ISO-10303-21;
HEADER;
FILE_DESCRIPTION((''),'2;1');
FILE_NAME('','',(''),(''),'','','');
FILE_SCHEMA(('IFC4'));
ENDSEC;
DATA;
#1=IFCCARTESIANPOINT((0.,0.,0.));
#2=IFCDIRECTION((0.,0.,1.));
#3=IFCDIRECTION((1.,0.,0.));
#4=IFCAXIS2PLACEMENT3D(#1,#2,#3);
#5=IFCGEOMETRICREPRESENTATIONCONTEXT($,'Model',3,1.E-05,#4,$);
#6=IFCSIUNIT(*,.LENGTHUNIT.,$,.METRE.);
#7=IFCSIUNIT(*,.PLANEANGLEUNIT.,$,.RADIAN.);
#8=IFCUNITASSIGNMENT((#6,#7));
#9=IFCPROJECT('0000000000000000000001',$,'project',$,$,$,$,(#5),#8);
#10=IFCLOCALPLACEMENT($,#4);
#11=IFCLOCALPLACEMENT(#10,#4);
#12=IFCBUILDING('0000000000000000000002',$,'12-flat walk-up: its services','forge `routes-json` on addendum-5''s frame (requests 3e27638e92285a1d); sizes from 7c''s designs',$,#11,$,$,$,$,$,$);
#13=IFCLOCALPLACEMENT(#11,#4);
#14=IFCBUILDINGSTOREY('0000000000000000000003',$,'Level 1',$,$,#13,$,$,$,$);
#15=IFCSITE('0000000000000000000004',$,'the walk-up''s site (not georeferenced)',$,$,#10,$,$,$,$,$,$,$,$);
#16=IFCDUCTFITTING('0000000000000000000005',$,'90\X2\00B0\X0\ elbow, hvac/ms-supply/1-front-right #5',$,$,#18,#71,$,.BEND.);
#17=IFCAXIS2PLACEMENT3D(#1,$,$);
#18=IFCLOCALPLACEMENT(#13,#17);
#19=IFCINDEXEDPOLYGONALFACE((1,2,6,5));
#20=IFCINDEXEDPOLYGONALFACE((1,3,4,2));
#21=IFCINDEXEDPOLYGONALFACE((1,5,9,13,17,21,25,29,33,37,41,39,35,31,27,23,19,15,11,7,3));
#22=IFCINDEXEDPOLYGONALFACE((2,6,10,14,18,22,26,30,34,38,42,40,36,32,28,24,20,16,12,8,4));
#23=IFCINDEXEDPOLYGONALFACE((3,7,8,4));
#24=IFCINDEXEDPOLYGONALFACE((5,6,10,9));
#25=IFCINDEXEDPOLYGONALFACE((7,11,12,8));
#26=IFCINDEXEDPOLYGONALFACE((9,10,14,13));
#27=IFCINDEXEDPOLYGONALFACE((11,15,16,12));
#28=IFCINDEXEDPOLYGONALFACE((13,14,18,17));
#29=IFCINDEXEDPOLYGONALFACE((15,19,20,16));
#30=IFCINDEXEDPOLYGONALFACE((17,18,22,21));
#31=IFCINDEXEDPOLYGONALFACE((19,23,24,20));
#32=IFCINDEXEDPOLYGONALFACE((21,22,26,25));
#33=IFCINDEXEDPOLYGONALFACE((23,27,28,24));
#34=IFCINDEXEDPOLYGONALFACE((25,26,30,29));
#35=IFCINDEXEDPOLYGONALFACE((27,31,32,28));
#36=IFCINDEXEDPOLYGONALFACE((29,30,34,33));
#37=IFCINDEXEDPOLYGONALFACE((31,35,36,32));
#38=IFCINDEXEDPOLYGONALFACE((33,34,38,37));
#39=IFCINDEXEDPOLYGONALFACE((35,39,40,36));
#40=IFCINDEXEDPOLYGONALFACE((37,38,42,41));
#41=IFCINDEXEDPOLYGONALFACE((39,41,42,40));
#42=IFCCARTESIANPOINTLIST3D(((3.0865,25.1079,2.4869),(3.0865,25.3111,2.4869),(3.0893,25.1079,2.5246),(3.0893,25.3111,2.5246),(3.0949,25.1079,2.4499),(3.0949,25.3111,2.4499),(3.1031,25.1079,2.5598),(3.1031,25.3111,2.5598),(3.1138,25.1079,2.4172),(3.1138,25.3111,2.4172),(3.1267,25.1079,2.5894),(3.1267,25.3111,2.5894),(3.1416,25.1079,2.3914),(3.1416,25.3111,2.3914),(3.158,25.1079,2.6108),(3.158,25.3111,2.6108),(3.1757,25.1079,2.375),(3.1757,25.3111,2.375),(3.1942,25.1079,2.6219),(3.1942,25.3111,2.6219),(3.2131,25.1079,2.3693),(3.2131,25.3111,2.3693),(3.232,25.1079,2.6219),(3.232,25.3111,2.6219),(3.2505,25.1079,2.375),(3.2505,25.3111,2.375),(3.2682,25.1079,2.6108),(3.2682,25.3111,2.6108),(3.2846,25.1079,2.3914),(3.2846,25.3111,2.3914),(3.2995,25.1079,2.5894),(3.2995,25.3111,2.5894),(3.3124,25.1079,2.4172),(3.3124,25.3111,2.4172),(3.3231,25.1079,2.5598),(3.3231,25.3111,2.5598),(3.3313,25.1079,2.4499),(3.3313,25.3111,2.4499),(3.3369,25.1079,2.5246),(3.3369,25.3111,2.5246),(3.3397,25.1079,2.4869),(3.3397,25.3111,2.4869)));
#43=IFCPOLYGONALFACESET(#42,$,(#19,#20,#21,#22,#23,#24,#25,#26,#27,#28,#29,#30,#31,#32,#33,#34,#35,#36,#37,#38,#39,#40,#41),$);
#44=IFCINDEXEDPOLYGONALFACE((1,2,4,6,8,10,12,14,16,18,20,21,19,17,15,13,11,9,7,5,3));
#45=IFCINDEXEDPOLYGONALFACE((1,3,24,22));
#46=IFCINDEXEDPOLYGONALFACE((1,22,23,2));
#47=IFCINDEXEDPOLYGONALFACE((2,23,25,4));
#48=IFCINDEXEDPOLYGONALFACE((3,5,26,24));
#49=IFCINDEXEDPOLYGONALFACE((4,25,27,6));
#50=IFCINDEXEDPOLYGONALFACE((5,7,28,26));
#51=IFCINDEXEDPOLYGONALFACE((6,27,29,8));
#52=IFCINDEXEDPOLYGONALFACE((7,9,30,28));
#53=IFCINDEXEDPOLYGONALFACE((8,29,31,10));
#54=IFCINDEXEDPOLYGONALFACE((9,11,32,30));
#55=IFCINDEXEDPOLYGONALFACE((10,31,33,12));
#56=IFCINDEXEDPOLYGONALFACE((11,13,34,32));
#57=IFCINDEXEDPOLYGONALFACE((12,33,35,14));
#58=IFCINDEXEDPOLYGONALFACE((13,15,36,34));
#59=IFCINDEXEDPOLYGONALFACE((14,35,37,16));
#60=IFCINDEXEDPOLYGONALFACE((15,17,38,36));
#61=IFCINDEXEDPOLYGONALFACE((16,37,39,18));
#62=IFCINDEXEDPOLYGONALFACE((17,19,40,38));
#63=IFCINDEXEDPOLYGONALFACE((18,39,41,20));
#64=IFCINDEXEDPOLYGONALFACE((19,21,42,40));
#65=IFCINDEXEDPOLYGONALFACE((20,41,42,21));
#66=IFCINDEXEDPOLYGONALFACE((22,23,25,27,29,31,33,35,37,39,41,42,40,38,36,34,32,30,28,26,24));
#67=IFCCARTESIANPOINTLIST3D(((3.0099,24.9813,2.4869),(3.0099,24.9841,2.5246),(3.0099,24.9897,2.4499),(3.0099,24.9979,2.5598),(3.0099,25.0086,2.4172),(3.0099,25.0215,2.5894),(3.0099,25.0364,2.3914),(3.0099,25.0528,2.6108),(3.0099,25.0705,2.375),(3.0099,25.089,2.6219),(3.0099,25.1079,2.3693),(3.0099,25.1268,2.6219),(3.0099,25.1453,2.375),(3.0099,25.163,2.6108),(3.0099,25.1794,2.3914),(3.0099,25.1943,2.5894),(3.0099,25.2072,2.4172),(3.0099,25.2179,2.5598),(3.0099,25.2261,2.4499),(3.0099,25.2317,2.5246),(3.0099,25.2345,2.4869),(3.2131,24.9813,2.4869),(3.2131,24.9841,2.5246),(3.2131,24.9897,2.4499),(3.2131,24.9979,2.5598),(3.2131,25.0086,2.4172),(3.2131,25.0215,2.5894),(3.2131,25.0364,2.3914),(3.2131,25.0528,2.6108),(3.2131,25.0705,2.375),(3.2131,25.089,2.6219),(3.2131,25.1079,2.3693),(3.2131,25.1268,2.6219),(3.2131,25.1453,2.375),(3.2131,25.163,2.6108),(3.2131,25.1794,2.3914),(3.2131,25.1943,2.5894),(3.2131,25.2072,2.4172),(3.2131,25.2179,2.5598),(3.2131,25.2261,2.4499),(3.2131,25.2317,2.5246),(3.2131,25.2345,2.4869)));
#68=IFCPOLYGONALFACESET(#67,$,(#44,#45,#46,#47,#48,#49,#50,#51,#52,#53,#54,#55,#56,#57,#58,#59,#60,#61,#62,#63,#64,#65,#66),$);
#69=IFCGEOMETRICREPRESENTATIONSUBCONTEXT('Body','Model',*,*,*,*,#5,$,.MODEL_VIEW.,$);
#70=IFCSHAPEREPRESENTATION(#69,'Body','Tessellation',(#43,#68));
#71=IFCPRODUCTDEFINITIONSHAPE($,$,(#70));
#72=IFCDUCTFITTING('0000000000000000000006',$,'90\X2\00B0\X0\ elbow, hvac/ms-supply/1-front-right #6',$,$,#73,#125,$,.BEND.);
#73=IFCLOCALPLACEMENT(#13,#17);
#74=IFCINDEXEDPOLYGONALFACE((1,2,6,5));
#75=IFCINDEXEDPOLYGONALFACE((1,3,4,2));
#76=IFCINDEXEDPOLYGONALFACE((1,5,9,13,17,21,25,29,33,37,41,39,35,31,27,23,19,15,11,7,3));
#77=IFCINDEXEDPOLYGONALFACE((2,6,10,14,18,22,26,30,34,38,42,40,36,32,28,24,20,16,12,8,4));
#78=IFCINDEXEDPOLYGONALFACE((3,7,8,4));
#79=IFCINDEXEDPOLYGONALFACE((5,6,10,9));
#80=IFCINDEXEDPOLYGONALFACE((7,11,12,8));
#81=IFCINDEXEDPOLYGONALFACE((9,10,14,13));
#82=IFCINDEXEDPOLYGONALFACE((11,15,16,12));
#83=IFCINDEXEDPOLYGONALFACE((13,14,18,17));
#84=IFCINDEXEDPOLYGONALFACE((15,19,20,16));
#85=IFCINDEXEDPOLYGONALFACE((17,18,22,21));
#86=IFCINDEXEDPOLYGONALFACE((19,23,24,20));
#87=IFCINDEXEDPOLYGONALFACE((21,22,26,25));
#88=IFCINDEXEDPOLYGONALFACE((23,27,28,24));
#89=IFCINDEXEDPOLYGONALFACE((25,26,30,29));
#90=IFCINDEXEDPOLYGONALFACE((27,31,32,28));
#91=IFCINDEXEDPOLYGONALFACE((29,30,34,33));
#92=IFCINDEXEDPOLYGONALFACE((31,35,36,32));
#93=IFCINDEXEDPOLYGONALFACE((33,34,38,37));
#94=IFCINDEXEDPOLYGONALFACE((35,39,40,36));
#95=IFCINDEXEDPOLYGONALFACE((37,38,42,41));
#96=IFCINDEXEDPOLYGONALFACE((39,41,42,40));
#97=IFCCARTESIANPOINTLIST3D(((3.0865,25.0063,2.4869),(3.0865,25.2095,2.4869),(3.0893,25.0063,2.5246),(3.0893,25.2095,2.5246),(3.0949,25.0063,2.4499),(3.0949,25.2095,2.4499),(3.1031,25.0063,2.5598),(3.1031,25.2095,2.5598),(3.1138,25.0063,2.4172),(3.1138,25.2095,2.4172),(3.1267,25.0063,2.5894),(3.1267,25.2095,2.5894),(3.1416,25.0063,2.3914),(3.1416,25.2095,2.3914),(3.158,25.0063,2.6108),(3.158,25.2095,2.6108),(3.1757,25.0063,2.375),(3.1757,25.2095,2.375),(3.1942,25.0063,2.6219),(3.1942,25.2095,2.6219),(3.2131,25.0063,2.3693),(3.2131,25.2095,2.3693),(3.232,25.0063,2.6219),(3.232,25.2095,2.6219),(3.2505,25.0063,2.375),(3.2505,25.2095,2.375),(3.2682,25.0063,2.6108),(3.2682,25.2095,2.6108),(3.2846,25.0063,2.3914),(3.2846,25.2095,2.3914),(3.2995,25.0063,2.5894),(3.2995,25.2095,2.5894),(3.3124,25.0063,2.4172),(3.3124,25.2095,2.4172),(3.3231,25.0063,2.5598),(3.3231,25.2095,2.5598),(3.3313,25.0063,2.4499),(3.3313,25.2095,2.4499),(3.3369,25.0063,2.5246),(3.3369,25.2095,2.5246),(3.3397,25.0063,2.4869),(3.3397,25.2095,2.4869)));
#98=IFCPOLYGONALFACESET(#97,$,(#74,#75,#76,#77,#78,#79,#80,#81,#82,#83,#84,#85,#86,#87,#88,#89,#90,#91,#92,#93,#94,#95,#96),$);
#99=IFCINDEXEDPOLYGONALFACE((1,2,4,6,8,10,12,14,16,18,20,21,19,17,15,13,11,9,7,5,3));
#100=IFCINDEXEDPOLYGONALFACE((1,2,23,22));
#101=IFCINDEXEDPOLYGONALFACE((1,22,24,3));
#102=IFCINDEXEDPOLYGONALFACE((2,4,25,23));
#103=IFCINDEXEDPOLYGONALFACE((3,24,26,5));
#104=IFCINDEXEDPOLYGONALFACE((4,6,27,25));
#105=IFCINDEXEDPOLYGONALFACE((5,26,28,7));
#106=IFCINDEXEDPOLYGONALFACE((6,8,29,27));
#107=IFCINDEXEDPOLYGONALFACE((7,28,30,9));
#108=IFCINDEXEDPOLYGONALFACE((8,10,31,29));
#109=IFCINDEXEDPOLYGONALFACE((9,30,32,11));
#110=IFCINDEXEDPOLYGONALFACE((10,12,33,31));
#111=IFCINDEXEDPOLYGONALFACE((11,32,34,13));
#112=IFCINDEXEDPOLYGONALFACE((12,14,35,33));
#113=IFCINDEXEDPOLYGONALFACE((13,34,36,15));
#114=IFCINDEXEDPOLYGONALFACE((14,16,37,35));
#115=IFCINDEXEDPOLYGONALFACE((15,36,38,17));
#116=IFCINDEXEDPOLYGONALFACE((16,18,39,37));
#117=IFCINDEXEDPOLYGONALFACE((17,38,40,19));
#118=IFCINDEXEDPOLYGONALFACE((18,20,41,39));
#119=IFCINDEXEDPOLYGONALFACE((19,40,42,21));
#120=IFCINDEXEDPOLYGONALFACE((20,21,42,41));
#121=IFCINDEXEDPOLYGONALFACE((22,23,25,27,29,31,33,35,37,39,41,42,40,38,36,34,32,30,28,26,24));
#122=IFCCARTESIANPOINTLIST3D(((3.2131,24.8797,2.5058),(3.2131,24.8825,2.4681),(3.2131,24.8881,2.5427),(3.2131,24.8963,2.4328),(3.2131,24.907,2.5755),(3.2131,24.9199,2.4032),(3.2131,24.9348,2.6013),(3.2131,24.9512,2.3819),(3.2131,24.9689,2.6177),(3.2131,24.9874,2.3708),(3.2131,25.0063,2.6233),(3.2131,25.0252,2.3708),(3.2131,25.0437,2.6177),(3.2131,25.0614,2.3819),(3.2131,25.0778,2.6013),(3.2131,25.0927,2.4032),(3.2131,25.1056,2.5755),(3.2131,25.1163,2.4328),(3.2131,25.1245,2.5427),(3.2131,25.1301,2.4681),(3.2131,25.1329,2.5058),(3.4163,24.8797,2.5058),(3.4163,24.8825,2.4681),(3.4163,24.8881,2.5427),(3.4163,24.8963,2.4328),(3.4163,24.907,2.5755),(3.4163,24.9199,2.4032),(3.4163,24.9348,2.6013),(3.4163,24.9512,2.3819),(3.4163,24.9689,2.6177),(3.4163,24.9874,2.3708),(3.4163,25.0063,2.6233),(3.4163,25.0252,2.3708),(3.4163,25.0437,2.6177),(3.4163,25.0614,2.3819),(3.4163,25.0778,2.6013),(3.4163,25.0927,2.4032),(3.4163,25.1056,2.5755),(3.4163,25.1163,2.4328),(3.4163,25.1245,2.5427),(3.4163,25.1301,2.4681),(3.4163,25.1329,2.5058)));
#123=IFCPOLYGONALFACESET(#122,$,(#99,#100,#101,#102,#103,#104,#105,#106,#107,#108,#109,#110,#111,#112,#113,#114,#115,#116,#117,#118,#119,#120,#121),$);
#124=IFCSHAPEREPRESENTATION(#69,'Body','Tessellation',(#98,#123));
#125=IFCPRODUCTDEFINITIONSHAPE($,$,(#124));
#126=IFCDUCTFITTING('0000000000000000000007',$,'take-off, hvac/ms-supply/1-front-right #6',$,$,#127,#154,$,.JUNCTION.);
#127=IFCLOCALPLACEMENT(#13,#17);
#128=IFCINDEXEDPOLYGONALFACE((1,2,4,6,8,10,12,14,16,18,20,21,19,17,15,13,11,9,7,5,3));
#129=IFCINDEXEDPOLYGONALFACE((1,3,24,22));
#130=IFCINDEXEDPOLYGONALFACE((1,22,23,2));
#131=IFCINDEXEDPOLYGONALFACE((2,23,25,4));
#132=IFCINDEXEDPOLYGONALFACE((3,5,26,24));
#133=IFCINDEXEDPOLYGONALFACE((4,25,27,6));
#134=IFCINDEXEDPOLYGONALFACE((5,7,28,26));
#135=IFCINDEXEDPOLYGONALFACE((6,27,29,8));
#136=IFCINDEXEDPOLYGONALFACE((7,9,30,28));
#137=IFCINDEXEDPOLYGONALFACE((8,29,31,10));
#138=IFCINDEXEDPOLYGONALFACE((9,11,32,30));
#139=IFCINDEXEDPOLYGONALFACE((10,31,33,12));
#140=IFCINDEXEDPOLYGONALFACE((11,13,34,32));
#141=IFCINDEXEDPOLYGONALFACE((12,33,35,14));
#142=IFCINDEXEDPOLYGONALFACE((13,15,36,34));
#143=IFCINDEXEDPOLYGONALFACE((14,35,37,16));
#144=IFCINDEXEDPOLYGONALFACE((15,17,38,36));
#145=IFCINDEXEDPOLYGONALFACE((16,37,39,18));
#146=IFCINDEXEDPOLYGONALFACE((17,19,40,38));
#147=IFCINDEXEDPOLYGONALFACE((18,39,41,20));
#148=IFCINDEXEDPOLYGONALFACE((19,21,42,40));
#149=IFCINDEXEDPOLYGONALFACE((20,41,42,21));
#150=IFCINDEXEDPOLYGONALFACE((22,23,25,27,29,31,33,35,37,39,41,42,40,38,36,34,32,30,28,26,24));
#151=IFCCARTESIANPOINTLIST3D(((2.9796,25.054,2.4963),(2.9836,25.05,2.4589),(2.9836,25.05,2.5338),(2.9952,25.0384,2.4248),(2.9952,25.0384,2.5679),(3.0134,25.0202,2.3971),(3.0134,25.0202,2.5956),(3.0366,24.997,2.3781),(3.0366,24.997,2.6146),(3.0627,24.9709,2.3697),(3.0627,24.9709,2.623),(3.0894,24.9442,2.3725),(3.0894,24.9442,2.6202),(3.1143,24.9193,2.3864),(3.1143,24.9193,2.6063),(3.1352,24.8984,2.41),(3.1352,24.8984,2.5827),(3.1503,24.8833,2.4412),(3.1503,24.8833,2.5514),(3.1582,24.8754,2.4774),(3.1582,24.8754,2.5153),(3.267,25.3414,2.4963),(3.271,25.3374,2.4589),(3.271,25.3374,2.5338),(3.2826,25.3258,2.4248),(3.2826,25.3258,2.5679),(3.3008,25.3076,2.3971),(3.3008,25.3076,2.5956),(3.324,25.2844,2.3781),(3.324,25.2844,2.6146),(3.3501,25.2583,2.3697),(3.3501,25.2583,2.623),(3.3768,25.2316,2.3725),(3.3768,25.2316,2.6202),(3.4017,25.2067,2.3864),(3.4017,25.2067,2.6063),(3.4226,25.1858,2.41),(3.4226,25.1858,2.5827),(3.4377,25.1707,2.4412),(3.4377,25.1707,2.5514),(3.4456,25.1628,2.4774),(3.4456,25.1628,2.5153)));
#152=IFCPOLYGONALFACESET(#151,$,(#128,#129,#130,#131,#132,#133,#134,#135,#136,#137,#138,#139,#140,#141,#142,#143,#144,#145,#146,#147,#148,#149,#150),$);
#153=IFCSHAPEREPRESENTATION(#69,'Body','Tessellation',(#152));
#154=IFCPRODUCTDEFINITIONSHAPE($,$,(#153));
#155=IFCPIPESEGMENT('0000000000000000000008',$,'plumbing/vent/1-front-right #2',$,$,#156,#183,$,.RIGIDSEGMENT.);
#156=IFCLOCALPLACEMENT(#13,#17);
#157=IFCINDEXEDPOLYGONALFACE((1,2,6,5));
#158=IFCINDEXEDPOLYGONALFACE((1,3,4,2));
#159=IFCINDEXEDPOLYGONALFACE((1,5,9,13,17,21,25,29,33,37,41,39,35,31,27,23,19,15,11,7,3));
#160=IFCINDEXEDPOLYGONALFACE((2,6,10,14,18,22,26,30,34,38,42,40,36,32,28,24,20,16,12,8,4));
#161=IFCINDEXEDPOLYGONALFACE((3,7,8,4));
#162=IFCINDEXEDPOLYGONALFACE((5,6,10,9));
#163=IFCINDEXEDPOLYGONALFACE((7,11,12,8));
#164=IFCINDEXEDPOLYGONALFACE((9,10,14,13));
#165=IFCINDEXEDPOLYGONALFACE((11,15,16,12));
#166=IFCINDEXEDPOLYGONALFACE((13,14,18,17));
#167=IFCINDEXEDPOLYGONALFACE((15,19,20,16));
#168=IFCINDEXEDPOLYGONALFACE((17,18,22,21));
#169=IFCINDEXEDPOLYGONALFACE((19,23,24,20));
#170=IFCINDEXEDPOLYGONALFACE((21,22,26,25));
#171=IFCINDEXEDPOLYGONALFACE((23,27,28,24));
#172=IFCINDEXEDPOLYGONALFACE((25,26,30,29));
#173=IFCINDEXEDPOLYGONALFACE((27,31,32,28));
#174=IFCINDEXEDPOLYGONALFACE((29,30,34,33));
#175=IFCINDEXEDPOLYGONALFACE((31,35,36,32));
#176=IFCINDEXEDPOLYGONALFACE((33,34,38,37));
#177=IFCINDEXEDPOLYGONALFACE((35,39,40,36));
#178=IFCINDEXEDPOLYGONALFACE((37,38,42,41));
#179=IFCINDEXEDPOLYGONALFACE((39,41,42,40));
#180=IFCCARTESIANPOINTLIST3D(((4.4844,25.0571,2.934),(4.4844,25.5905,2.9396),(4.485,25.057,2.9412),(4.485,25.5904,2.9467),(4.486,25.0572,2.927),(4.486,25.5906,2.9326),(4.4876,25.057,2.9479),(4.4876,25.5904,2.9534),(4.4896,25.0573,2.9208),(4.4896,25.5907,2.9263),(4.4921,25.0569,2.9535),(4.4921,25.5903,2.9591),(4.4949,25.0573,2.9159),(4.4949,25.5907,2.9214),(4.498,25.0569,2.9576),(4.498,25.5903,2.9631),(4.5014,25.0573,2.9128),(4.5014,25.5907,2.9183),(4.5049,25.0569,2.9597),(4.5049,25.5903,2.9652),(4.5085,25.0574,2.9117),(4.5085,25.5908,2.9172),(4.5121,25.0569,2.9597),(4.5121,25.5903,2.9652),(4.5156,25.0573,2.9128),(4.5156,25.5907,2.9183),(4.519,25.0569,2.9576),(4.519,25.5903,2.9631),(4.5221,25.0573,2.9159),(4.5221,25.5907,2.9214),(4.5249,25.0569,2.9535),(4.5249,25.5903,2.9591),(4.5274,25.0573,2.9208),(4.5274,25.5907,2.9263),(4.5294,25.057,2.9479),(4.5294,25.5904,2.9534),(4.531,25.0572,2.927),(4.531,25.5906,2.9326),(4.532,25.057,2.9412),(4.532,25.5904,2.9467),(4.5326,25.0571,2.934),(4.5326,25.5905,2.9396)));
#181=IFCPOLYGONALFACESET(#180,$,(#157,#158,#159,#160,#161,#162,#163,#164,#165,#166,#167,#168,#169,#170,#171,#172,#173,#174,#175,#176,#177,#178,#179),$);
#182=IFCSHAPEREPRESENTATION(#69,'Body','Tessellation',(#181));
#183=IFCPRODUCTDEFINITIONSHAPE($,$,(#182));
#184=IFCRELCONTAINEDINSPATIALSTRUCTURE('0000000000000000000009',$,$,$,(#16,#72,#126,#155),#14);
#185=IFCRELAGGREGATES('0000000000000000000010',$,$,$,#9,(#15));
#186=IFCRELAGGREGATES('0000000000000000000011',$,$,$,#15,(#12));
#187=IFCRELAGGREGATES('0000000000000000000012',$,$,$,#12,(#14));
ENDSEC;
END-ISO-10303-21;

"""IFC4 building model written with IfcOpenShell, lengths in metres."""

from ifc_helpers import new_model, entity, si_unit, frame, origin_with_axes, place, context, subcontext, project, spatial, element, save


model = new_model("IFC4")

# Units and contexts
model_context = context("Model", 3, precision=1e-05, world=origin_with_axes())
body_context = subcontext(model_context, "Body", "Model", "MODEL_VIEW")
ifc_project = project(units=[si_unit("LENGTHUNIT", "METRE"), si_unit("PLANEANGLEUNIT", "RADIAN")], contexts=[model_context])

# Site, building, storey
site_placement = place(None, origin_with_axes())
site = spatial("IfcSite", under=ifc_project, at=site_placement, Name="the walk-up's site (not georeferenced)")
building_placement = place(site_placement, origin_with_axes())
building = spatial("IfcBuilding", under=site, at=building_placement, Name="12-flat walk-up: its services", Description="forge `routes-json` on addendum-5's frame (requests 3e27638e92285a1d); sizes from 7c's designs")
storey_placement = place(building_placement, origin_with_axes())
storey = spatial("IfcBuildingStorey", under=building, at=storey_placement, Name="Level 1")

# Duct fittings
duct_fitting_1_placement = place(storey_placement, frame((3.2131, 25.3111, 2.4963), z_axis=(0.0, 0.0, 1.0), x_axis=(1.0, 0.0, 0.0)))
element("IfcDuctFitting", 1, at=duct_fitting_1_placement, inside=storey, Name="90° elbow, hvac/ms-supply/1-front-right #5", PredefinedType="BEND", context=body_context, shape_type="AdvancedSweptSolid", body=[
    entity("IfcSweptDiskSolid", entity("IfcPolyline", [entity("IfcCartesianPoint", [0.0, 0.0, 0.0]), entity("IfcCartesianPoint", [0.0, -0.2032, 0.0])]), 0.127),
    entity("IfcSweptDiskSolid", entity("IfcPolyline", [entity("IfcCartesianPoint", [0.0, -0.2032, 0.0]), entity("IfcCartesianPoint", [-0.2032, -0.2032, 0.0])]), 0.127),
])
duct_fitting_2_placement = place(storey_placement, frame((3.2131, 25.2095, 2.4963), z_axis=(0.0, 0.0, 1.0), x_axis=(1.0, 0.0, 0.0)))
element("IfcDuctFitting", 2, at=duct_fitting_2_placement, inside=storey, Name="90° elbow, hvac/ms-supply/1-front-right #6", PredefinedType="BEND", context=body_context, shape_type="AdvancedSweptSolid", body=[
    entity("IfcSweptDiskSolid", entity("IfcPolyline", [entity("IfcCartesianPoint", [0.0, 0.0, 0.0]), entity("IfcCartesianPoint", [0.0, -0.2032, 0.0])]), 0.127),
    entity("IfcSweptDiskSolid", entity("IfcPolyline", [entity("IfcCartesianPoint", [0.0, -0.2032, 0.0]), entity("IfcCartesianPoint", [0.2032, -0.2032, 0.0])]), 0.127),
])
duct_fitting_3_placement = place(storey_placement, frame((3.3568, 25.2516, 2.4963), z_axis=(0.0, 0.0, 1.0), x_axis=(1.0, 0.0, 0.0)))
element("IfcDuctFitting", 3, at=duct_fitting_3_placement, inside=storey, Name="take-off, hvac/ms-supply/1-front-right #6", PredefinedType="JUNCTION", context=body_context, shape_type="AdvancedSweptSolid", body=[
    entity("IfcSweptDiskSolid", entity("IfcPolyline", [entity("IfcCartesianPoint", [0.0, 0.0, 0.0]), entity("IfcCartesianPoint", [-0.2874, -0.2874, 0.0])]), 0.127),
])

# Pipe segment
pipe_segment_1_placement = place(storey_placement, frame((4.5085, 25.5905, 2.9414), z_axis=(0.0, 0.0, 1.0), x_axis=(1.0, 0.0, 0.0)))
element("IfcPipeSegment", 4, at=pipe_segment_1_placement, inside=storey, Name="plumbing/vent/1-front-right #2", PredefinedType="RIGIDSEGMENT", context=body_context, shape_type="AdvancedSweptSolid", body=[
    entity("IfcSweptDiskSolid", entity("IfcPolyline", [entity("IfcCartesianPoint", [0.0, 0.0, 0.0]), entity("IfcCartesianPoint", [0.0, -0.5334, -0.0056])]), 0.0241),
])

save(model, "model.ifc")
